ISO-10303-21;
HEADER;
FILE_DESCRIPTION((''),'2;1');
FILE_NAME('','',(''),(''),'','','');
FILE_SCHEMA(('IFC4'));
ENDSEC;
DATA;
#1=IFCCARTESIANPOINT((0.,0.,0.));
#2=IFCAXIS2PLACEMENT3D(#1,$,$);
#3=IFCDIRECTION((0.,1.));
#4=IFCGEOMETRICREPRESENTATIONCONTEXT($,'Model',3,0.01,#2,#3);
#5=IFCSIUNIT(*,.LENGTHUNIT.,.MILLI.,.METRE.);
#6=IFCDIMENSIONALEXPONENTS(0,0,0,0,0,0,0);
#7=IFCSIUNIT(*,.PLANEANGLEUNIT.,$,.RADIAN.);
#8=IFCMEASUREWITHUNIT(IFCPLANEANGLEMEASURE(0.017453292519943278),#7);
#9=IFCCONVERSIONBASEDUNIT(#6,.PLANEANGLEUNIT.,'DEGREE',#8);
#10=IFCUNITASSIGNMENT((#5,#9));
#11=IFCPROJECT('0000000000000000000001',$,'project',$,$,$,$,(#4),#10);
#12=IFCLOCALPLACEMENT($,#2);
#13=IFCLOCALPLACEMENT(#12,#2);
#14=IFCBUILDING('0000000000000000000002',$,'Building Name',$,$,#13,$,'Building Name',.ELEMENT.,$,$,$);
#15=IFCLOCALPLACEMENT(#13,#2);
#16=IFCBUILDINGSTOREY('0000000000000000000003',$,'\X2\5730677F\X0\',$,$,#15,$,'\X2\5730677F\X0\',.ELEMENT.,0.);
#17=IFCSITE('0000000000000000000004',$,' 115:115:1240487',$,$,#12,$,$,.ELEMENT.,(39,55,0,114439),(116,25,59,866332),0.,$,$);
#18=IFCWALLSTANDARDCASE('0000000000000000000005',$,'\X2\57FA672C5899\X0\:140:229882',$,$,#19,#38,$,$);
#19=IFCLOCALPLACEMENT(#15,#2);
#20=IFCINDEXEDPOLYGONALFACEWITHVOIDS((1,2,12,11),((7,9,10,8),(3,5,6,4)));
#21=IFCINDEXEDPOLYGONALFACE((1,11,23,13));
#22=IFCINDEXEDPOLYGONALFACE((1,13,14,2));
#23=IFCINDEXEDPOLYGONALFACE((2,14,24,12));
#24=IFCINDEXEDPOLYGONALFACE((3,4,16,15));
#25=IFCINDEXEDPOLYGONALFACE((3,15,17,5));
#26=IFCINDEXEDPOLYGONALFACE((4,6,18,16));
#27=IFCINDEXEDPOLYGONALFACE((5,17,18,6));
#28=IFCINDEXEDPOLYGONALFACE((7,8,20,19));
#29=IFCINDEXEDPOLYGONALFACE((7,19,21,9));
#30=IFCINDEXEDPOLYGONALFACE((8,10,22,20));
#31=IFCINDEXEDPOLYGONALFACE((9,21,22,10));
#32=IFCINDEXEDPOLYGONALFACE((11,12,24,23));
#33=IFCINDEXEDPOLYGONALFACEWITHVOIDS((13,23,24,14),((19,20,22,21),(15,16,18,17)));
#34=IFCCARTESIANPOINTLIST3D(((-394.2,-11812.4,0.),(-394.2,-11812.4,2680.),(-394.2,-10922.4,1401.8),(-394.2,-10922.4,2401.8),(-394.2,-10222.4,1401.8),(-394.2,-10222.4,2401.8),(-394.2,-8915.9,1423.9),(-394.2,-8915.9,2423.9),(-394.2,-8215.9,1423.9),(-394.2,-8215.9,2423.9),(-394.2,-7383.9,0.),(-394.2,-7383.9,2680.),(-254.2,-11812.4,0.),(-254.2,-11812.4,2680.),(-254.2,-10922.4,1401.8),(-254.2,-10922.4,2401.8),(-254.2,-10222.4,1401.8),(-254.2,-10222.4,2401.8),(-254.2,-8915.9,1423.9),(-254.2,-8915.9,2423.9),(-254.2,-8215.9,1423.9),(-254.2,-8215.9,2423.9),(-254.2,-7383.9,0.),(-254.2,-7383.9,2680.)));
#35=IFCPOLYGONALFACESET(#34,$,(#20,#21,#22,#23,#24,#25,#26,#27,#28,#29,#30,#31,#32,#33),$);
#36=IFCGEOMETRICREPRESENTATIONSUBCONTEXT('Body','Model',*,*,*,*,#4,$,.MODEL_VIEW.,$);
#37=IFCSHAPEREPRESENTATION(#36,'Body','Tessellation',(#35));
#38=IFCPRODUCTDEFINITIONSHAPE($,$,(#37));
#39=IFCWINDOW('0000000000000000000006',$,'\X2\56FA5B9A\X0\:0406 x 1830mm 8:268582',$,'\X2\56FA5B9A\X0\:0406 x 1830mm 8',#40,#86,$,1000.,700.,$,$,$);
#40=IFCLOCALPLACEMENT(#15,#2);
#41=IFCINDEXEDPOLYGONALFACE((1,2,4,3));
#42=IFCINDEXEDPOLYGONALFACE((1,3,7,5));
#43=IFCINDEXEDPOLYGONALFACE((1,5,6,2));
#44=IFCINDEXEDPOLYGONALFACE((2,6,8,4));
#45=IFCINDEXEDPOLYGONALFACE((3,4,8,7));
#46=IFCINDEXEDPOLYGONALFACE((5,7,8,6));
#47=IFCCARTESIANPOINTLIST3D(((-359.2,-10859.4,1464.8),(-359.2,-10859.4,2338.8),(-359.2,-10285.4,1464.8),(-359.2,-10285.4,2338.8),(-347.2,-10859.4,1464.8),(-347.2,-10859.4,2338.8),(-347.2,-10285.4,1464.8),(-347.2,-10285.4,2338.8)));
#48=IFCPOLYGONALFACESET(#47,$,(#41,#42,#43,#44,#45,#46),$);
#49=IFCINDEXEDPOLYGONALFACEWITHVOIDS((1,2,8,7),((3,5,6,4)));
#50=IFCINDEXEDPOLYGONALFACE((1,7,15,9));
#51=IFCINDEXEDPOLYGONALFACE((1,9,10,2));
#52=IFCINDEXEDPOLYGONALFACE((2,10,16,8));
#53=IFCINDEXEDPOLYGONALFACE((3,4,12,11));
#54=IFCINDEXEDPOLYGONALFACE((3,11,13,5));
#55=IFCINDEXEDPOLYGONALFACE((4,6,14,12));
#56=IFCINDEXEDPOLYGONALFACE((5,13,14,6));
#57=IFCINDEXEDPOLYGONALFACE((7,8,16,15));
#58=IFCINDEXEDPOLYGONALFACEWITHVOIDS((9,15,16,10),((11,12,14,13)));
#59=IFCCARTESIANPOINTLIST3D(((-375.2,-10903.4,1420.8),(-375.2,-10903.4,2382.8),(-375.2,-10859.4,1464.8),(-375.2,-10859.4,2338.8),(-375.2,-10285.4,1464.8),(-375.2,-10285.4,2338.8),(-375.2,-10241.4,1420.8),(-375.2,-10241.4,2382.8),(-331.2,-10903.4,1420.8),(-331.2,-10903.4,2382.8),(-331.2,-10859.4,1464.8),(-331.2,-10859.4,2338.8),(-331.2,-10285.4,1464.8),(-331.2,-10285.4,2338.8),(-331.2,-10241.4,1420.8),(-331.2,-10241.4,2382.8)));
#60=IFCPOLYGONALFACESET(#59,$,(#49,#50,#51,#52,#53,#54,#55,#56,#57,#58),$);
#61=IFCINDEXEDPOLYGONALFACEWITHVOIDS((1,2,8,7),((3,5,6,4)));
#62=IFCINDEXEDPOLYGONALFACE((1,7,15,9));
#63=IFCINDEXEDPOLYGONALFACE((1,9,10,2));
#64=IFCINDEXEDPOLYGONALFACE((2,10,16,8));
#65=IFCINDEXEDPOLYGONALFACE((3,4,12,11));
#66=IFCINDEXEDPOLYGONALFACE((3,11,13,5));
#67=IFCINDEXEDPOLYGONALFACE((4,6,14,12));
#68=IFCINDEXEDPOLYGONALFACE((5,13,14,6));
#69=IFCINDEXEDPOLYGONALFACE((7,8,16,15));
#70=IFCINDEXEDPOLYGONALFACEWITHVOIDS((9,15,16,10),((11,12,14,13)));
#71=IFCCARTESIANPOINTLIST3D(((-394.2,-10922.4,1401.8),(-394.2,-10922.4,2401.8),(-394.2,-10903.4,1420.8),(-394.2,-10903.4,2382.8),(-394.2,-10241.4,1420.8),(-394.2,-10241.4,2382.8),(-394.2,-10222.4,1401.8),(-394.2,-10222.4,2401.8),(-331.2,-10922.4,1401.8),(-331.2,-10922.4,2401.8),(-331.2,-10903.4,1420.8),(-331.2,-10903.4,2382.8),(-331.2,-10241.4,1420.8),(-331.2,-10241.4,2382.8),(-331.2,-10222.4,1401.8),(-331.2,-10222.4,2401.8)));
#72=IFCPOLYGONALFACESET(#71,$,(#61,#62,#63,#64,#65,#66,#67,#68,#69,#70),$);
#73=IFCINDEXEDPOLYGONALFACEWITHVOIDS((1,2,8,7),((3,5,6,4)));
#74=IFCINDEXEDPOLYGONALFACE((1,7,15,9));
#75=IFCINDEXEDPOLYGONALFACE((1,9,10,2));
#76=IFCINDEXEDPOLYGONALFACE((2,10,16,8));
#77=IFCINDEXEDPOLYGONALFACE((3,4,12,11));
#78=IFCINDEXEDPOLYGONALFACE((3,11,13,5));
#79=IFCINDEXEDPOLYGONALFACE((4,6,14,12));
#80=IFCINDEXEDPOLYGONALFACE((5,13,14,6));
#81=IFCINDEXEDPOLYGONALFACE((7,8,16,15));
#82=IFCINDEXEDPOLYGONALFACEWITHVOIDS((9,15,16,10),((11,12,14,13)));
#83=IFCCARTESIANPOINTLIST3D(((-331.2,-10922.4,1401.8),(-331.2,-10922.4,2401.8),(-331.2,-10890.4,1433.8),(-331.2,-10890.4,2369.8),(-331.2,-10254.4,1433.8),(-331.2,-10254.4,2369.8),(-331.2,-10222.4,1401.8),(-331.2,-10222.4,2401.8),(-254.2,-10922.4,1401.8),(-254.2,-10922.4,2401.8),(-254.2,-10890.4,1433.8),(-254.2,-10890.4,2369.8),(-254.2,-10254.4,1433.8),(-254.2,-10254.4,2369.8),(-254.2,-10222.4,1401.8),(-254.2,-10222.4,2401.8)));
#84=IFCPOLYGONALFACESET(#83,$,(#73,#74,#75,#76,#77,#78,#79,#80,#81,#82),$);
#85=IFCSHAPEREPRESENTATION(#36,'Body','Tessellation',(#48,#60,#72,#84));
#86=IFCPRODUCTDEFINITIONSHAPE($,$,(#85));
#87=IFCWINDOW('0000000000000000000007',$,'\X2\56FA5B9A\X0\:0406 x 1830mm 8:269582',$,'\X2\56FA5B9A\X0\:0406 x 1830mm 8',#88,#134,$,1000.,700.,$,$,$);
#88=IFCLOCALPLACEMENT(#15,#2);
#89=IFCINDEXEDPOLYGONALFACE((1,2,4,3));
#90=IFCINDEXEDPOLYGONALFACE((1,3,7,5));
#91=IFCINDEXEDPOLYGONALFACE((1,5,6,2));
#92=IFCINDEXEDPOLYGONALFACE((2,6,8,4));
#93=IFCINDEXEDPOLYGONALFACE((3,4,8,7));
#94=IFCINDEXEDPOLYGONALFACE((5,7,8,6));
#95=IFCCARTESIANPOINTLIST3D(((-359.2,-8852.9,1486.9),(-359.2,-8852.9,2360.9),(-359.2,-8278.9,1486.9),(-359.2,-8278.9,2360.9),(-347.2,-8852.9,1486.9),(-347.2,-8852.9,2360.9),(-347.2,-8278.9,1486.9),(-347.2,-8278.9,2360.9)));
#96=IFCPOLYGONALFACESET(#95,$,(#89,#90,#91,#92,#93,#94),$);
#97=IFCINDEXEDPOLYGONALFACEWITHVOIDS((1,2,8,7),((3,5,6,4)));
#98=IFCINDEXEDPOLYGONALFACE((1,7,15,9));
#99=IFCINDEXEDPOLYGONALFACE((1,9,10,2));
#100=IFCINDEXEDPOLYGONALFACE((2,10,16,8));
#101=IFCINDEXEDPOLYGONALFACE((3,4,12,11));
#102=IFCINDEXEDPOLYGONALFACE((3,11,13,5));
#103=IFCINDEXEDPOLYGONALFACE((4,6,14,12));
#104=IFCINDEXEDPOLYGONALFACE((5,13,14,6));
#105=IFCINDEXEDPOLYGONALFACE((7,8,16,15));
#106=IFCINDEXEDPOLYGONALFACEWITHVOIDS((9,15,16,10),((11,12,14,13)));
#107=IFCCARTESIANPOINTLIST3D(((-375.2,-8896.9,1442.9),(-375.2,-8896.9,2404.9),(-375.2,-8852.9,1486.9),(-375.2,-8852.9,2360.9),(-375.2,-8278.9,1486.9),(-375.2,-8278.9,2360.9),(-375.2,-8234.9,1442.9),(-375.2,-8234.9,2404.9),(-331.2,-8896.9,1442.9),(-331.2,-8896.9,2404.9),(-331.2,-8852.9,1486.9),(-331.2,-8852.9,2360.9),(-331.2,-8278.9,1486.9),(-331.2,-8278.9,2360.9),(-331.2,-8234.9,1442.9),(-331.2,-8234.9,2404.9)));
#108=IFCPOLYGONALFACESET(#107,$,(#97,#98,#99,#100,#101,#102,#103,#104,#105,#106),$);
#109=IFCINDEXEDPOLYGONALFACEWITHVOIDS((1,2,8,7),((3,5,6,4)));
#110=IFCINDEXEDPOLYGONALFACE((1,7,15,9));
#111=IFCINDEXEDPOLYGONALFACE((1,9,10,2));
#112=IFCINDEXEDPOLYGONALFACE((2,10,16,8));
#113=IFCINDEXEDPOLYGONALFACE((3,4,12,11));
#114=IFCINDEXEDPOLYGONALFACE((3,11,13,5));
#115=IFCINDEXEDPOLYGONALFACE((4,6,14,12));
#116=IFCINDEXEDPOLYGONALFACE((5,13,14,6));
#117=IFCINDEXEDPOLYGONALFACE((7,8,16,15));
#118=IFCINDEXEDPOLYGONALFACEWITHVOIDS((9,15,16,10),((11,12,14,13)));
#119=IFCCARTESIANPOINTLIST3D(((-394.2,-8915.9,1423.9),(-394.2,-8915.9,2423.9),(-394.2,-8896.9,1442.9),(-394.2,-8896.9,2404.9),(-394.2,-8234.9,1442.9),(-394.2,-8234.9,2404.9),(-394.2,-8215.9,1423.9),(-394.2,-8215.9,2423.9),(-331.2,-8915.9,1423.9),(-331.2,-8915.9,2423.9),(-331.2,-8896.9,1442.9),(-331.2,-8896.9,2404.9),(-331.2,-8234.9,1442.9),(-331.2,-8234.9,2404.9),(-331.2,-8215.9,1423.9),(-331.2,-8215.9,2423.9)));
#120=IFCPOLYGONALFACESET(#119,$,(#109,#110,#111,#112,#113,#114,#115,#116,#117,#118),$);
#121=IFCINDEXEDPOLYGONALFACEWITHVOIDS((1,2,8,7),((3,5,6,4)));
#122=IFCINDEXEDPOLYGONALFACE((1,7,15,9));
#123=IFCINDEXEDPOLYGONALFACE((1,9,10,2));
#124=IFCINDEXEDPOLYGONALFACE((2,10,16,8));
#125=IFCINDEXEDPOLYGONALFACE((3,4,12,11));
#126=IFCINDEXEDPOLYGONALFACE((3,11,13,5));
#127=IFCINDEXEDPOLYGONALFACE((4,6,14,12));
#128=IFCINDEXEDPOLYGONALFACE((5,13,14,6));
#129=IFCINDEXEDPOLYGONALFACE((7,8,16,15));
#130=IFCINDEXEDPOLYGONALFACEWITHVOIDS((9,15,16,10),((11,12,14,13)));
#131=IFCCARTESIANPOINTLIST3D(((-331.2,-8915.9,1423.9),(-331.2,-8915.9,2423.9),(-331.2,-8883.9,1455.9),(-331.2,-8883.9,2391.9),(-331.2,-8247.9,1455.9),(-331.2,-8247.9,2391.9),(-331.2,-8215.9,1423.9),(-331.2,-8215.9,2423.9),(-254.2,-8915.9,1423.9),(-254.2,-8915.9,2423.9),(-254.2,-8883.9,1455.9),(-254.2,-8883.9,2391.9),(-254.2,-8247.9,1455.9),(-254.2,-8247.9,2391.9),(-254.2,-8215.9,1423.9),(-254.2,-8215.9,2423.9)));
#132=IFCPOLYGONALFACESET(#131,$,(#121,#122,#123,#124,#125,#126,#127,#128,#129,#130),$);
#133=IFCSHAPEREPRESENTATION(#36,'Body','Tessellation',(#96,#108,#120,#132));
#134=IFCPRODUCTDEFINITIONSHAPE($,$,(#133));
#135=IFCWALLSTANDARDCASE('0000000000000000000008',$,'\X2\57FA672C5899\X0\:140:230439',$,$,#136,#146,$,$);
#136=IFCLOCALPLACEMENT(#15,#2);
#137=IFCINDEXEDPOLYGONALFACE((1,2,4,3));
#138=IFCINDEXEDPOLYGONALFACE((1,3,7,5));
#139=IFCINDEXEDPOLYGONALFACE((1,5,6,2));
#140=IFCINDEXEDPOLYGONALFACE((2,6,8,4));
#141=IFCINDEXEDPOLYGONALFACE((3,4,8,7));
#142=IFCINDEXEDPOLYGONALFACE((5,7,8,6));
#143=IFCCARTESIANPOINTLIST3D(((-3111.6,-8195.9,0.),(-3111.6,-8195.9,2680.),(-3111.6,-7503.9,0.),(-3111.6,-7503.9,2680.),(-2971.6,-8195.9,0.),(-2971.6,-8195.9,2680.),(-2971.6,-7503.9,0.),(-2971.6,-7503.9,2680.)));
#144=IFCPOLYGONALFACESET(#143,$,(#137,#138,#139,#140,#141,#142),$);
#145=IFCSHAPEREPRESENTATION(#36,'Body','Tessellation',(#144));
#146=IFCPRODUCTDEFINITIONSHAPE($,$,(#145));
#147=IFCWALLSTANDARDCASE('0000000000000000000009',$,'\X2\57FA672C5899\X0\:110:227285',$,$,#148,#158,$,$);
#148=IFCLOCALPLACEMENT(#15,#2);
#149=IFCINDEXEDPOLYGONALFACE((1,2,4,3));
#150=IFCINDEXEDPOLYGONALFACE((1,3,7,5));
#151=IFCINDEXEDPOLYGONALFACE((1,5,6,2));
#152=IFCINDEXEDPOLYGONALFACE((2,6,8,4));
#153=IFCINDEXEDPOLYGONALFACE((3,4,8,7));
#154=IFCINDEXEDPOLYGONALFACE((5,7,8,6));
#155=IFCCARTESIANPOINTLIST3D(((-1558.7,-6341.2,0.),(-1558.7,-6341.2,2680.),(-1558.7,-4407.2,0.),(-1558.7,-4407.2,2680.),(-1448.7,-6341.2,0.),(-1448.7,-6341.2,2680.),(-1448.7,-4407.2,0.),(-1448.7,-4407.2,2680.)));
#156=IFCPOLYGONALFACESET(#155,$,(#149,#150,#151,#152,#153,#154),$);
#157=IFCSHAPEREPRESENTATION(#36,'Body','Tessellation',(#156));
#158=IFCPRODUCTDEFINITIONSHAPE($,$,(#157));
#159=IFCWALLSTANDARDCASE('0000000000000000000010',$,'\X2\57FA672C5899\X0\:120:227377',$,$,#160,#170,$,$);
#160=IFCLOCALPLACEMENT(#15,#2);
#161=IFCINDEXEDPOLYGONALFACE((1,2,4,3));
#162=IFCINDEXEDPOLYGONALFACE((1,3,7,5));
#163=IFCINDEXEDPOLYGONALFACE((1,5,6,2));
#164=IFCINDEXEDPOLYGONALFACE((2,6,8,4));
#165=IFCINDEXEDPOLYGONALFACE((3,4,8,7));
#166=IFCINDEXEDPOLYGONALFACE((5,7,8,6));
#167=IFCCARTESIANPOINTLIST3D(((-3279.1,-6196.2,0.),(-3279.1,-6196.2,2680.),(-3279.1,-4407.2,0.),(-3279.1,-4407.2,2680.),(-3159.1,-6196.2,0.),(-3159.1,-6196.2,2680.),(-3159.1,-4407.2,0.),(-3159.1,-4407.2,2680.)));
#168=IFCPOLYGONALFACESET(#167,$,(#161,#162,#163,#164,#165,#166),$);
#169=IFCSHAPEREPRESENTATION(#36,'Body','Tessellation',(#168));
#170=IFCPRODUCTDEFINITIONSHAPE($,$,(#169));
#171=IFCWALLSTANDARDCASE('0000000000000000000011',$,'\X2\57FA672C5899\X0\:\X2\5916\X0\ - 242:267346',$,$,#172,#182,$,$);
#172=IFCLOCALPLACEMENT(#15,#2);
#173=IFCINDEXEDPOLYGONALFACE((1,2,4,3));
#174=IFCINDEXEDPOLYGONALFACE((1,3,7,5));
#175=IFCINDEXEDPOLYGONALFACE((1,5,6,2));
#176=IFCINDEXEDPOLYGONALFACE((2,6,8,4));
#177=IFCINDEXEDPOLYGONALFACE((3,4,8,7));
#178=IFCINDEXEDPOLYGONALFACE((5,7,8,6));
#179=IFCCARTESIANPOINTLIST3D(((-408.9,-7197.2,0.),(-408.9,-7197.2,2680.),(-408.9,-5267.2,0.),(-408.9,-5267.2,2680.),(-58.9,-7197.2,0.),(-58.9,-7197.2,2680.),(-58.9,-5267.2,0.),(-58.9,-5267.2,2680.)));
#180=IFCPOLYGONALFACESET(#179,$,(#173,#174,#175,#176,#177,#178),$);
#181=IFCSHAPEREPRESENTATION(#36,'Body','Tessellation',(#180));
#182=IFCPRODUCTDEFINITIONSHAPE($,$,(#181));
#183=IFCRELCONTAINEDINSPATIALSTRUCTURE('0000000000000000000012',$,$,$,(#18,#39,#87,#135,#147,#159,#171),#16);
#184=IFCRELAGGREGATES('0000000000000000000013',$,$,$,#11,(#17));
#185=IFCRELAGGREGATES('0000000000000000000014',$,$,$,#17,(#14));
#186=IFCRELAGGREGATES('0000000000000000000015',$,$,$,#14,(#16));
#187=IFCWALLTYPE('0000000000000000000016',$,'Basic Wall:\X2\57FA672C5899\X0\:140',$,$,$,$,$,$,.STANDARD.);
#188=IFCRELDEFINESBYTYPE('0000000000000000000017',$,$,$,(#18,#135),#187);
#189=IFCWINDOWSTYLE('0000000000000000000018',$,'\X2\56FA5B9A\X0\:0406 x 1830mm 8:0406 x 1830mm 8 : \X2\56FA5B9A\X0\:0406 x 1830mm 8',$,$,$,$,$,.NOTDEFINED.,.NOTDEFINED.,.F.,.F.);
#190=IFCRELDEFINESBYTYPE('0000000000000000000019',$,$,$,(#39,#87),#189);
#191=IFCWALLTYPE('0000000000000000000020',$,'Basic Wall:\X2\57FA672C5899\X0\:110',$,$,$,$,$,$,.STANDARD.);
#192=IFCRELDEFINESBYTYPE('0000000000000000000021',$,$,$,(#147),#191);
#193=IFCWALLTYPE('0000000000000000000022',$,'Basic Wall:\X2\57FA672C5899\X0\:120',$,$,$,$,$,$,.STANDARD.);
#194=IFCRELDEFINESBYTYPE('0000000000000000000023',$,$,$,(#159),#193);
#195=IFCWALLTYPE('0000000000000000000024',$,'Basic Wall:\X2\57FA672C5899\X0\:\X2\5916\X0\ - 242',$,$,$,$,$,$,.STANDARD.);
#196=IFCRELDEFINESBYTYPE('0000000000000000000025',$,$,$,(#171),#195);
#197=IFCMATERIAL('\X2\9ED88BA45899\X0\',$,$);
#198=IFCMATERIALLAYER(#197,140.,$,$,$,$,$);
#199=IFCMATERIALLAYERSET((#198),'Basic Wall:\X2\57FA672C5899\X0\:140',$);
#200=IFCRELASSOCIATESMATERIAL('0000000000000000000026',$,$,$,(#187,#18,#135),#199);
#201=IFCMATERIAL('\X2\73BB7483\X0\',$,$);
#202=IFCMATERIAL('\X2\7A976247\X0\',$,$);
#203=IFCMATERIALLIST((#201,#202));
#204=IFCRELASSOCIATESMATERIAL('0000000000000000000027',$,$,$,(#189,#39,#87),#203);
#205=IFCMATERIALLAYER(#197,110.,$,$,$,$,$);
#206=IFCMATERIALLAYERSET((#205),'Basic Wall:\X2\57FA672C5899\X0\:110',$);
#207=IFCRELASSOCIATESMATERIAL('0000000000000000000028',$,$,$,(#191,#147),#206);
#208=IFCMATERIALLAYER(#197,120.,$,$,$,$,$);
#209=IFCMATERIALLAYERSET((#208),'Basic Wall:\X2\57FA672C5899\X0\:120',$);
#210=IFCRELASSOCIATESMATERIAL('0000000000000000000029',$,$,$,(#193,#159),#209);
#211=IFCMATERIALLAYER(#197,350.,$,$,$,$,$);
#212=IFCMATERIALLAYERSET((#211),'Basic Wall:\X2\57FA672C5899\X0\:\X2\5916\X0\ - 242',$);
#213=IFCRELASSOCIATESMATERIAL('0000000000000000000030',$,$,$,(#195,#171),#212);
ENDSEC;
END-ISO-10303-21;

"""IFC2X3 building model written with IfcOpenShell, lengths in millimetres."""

from ifc_helpers import new_model, entity, si_unit, converted_unit, direction, frame, frame_2d, origin, origin_2d_with_axis, place, context, subcontext, project, spatial, polyline, rectangle, outline, extrude, source, transform, mapped, material, material_list, layer, layer_set, layer_usage, type_object, type_shapes, element, fill, save


model = new_model("IFC2X3")

# Units and contexts
model_context = context("Model", 3, precision=0.01, world=origin(), true_north=direction((0.0, 1.0)))
body_context = subcontext(model_context, "Body", "Model", "MODEL_VIEW")
ifc_project = project(units=[si_unit("LENGTHUNIT", "METRE", prefix="MILLI"), converted_unit("PLANEANGLEUNIT", "DEGREE", entity("IfcPlaneAngleMeasure", 0.017453292519943278), si_unit("PLANEANGLEUNIT", "RADIAN"), dimensions=[0, 0, 0, 0, 0, 0, 0])], contexts=[model_context])

# Site, building, storey
site_placement = place(None, origin())
site = spatial("IfcSite", under=ifc_project, at=site_placement, Name=" 115:115:1240487", CompositionType="ELEMENT", RefLatitude=(39, 55, 0, 114439), RefLongitude=(116, 25, 59, 866332), RefElevation=0.0)
building_placement = place(site_placement, origin())
building = spatial("IfcBuilding", under=site, at=building_placement, Name="Building Name", LongName="Building Name", CompositionType="ELEMENT")
storey_placement = place(building_placement, origin())
storey = spatial("IfcBuildingStorey", under=building, at=storey_placement, Name="地板", LongName="地板", CompositionType="ELEMENT", Elevation=0.0)

# Shared definitions
ifc_material_1 = material(Name="默认墙")

# Shared definitions
ifc_material_2 = material(Name="玻璃")
ifc_material_3 = material(Name="窗扇")
ifc_material_list = material_list([ifc_material_2, ifc_material_3])

# Shared definitions
ifc_layer_1 = layer(ifc_material_1, 140.0)
ifc_layer_set_1 = layer_set([ifc_layer_1], Name="Basic Wall:基本墙:140")
wall_type_1 = type_object("IfcWallType", Name="Basic Wall:基本墙:140", PredefinedType="STANDARD", material=ifc_layer_set_1)

# Wall, openings, windows
ifc_layer_usage_1 = layer_usage(ifc_layer_set_1, "AXIS2", "NEGATIVE", 70.0)
wall_1_placement = place(storey_placement, frame((-324.2, -11812.4, 0.0), z_axis=(0.0, 0.0, 1.0), x_axis=(0.0, 1.0, 0.0)))
wall_1 = element("IfcWallStandardCase", 1, at=wall_1_placement, inside=storey, type_object=wall_type_1, material=ifc_layer_usage_1, Name="基本墙:140:229882", context=body_context, shape_type="SweptSolid", body=[
    extrude(rectangle(XDim=4428.5, YDim=140.0, at=frame_2d((2214.3, 0.0), x_axis=(-1.0, 0.0))), origin(), (0.0, 0.0, 1.0), 2680.0),
])
opening_1_placement = place(wall_1_placement, frame((11812.4, -324.2, 0.0), z_axis=(0.0, 0.0, 1.0), x_axis=(0.0, -1.0, 0.0)))
opening_1 = element("IfcOpeningElement", 2, at=opening_1_placement, cuts=wall_1, ObjectType="Opening", context=body_context, shape_type="SweptSolid", body=[
    extrude(rectangle(XDim=1000.0, YDim=700.0, at=frame_2d((0.0, 0.0), x_axis=(0.0, 1.0))), frame((-252.8, -10572.4, 1901.8), z_axis=(-1.0, 0.0, 0.0), x_axis=(0.0, 1.0, 0.0)), (0.0, 0.0, 1.0), 142.8),
])
opening_2_placement = place(wall_1_placement, frame((11812.4, -324.2, 0.0), z_axis=(0.0, 0.0, 1.0), x_axis=(0.0, -1.0, 0.0)))
opening_2 = element("IfcOpeningElement", 3, at=opening_2_placement, cuts=wall_1, ObjectType="Opening", context=body_context, shape_type="SweptSolid", body=[
    extrude(rectangle(XDim=1000.0, YDim=700.0, at=frame_2d((0.0, 0.0), x_axis=(0.0, 1.0))), frame((-252.8, -8565.9, 1923.9), z_axis=(-1.0, 0.0, 0.0), x_axis=(0.0, 1.0, 0.0)), (0.0, 0.0, 1.0), 142.8),
])
window_style_1 = type_object("IfcWindowStyle", Name="固定:0406 x 1830mm 8:0406 x 1830mm 8 : 固定:0406 x 1830mm 8", ConstructionType="NOTDEFINED", OperationType="NOTDEFINED", ParameterTakesPrecedence=False, Sizeable=False, material=ifc_material_list)
shared_shape_1 = source(origin(), body_context, "Body", "SweptSolid", [
    extrude(rectangle(XDim=574.0, YDim=12.0, at=origin_2d_with_axis()), frame((350.0, -42.4, 63.0)), (0.0, 0.0, 1.0), 874.0),
    extrude(outline(polyline([(-481.0, -331.0), (481.0, -331.0), (481.0, 331.0), (-481.0, 331.0), (-481.0, -331.0)]), holes=[polyline([(437.0, 287.0), (437.0, -287.0), (-437.0, -287.0), (-437.0, 287.0), (437.0, 287.0)])]), frame((350.0, -64.4, 500.0), z_axis=(0.0, 1.0, 0.0), x_axis=(0.0, 0.0, -1.0)), (0.0, 0.0, 1.0), 44.0),
    extrude(outline(polyline([(-500.0, -350.0), (500.0, -350.0), (500.0, 350.0), (-500.0, 350.0), (-500.0, -350.0)]), holes=[polyline([(481.0, 331.0), (481.0, -331.0), (-481.0, -331.0), (-481.0, 331.0), (481.0, 331.0)])]), frame((350.0, -64.4, 500.0), z_axis=(0.0, 1.0, 0.0), x_axis=(0.0, 0.0, -1.0)), (0.0, 0.0, 1.0), 63.0),
    extrude(outline(polyline([(-500.0, -350.0), (500.0, -350.0), (500.0, 350.0), (-500.0, 350.0), (-500.0, -350.0)]), holes=[polyline([(468.0, 318.0), (468.0, -318.0), (-468.0, -318.0), (-468.0, 318.0), (468.0, 318.0)])]), frame((350.0, -141.4, 500.0), z_axis=(0.0, 1.0, 0.0), x_axis=(0.0, 0.0, -1.0)), (0.0, 0.0, 1.0), 77.0),
])
type_shapes(window_style_1, [shared_shape_1])
window_1_placement = place(opening_1_placement, frame((-395.6, -10922.4, 1401.8), z_axis=(0.0, 0.0, 1.0), x_axis=(0.0, 1.0, 0.0)))
window_1 = element("IfcWindow", 4, at=window_1_placement, inside=storey, type_object=window_style_1, material=ifc_material_list, Name="固定:0406 x 1830mm 8:268582", ObjectType="固定:0406 x 1830mm 8", OverallHeight=1000.0, OverallWidth=700.0, context=body_context, shape_type="MappedRepresentation", body=[
    mapped(shared_shape_1, transform((0.0, 0.0, 0.0), scale=1.0)),
])
fill(opening_1, window_1)
window_2_placement = place(opening_2_placement, frame((-395.6, -8915.9, 1423.9), z_axis=(0.0, 0.0, 1.0), x_axis=(0.0, 1.0, 0.0)))
window_2 = element("IfcWindow", 5, at=window_2_placement, inside=storey, type_object=window_style_1, material=ifc_material_list, Name="固定:0406 x 1830mm 8:269582", ObjectType="固定:0406 x 1830mm 8", OverallHeight=1000.0, OverallWidth=700.0, context=body_context, shape_type="MappedRepresentation", body=[
    mapped(shared_shape_1, transform((0.0, 0.0, 0.0), scale=1.0)),
])
fill(opening_2, window_2)

# Walls
ifc_layer_usage_2 = layer_usage(ifc_layer_set_1, "AXIS2", "NEGATIVE", 70.0)
wall_2_placement = place(storey_placement, frame((-3041.6, -7503.9, 0.0), z_axis=(0.0, 0.0, 1.0), x_axis=(0.0, -1.0, 0.0)))
element("IfcWallStandardCase", 6, at=wall_2_placement, inside=storey, type_object=wall_type_1, material=ifc_layer_usage_2, Name="基本墙:140:230439", context=body_context, shape_type="SweptSolid", body=[
    extrude(rectangle(XDim=692.0, YDim=140.0, at=frame_2d((346.0, 0.0), x_axis=(-1.0, 0.0))), origin(), (0.0, 0.0, 1.0), 2680.0),
])
ifc_layer_2 = layer(ifc_material_1, 110.0)
ifc_layer_set_2 = layer_set([ifc_layer_2], Name="Basic Wall:基本墙:110")
ifc_layer_usage_3 = layer_usage(ifc_layer_set_2, "AXIS2", "NEGATIVE", 55.0)
wall_type_2 = type_object("IfcWallType", Name="Basic Wall:基本墙:110", PredefinedType="STANDARD", material=ifc_layer_set_2)
wall_3_placement = place(storey_placement, frame((-1503.7, -4407.2, 0.0), z_axis=(0.0, 0.0, 1.0), x_axis=(0.0, -1.0, 0.0)))
element("IfcWallStandardCase", 7, at=wall_3_placement, inside=storey, type_object=wall_type_2, material=ifc_layer_usage_3, Name="基本墙:110:227285", context=body_context, shape_type="SweptSolid", body=[
    extrude(rectangle(XDim=1934.0, YDim=110.0, at=frame_2d((967.0, 0.0), x_axis=(-1.0, 0.0))), origin(), (0.0, 0.0, 1.0), 2680.0),
])
ifc_layer_3 = layer(ifc_material_1, 120.0)
ifc_layer_set_3 = layer_set([ifc_layer_3], Name="Basic Wall:基本墙:120")
ifc_layer_usage_4 = layer_usage(ifc_layer_set_3, "AXIS2", "NEGATIVE", 60.0)
wall_type_3 = type_object("IfcWallType", Name="Basic Wall:基本墙:120", PredefinedType="STANDARD", material=ifc_layer_set_3)
wall_4_placement = place(storey_placement, frame((-3219.1, -4407.2, 0.0), z_axis=(0.0, 0.0, 1.0), x_axis=(0.0, -1.0, 0.0)))
element("IfcWallStandardCase", 8, at=wall_4_placement, inside=storey, type_object=wall_type_3, material=ifc_layer_usage_4, Name="基本墙:120:227377", context=body_context, shape_type="SweptSolid", body=[
    extrude(rectangle(XDim=1789.0, YDim=120.0, at=frame_2d((894.5, 0.0), x_axis=(-1.0, 0.0))), origin(), (0.0, 0.0, 1.0), 2680.0),
])
ifc_layer_4 = layer(ifc_material_1, 350.0)
ifc_layer_set_4 = layer_set([ifc_layer_4], Name="Basic Wall:基本墙:外 - 242")
ifc_layer_usage_5 = layer_usage(ifc_layer_set_4, "AXIS2", "NEGATIVE", 175.0)
wall_type_4 = type_object("IfcWallType", Name="Basic Wall:基本墙:外 - 242", PredefinedType="STANDARD", material=ifc_layer_set_4)
wall_5_placement = place(storey_placement, frame((-233.9, -5267.2, 0.0), z_axis=(0.0, 0.0, 1.0), x_axis=(0.0, -1.0, 0.0)))
element("IfcWallStandardCase", 9, at=wall_5_placement, inside=storey, type_object=wall_type_4, material=ifc_layer_usage_5, Name="基本墙:外 - 242:267346", context=body_context, shape_type="SweptSolid", body=[
    extrude(rectangle(XDim=1930.0, YDim=350.0, at=frame_2d((965.0, 0.0), x_axis=(-1.0, 0.0))), origin(), (0.0, 0.0, 1.0), 2680.0),
])

save(model, "model.ifc")
